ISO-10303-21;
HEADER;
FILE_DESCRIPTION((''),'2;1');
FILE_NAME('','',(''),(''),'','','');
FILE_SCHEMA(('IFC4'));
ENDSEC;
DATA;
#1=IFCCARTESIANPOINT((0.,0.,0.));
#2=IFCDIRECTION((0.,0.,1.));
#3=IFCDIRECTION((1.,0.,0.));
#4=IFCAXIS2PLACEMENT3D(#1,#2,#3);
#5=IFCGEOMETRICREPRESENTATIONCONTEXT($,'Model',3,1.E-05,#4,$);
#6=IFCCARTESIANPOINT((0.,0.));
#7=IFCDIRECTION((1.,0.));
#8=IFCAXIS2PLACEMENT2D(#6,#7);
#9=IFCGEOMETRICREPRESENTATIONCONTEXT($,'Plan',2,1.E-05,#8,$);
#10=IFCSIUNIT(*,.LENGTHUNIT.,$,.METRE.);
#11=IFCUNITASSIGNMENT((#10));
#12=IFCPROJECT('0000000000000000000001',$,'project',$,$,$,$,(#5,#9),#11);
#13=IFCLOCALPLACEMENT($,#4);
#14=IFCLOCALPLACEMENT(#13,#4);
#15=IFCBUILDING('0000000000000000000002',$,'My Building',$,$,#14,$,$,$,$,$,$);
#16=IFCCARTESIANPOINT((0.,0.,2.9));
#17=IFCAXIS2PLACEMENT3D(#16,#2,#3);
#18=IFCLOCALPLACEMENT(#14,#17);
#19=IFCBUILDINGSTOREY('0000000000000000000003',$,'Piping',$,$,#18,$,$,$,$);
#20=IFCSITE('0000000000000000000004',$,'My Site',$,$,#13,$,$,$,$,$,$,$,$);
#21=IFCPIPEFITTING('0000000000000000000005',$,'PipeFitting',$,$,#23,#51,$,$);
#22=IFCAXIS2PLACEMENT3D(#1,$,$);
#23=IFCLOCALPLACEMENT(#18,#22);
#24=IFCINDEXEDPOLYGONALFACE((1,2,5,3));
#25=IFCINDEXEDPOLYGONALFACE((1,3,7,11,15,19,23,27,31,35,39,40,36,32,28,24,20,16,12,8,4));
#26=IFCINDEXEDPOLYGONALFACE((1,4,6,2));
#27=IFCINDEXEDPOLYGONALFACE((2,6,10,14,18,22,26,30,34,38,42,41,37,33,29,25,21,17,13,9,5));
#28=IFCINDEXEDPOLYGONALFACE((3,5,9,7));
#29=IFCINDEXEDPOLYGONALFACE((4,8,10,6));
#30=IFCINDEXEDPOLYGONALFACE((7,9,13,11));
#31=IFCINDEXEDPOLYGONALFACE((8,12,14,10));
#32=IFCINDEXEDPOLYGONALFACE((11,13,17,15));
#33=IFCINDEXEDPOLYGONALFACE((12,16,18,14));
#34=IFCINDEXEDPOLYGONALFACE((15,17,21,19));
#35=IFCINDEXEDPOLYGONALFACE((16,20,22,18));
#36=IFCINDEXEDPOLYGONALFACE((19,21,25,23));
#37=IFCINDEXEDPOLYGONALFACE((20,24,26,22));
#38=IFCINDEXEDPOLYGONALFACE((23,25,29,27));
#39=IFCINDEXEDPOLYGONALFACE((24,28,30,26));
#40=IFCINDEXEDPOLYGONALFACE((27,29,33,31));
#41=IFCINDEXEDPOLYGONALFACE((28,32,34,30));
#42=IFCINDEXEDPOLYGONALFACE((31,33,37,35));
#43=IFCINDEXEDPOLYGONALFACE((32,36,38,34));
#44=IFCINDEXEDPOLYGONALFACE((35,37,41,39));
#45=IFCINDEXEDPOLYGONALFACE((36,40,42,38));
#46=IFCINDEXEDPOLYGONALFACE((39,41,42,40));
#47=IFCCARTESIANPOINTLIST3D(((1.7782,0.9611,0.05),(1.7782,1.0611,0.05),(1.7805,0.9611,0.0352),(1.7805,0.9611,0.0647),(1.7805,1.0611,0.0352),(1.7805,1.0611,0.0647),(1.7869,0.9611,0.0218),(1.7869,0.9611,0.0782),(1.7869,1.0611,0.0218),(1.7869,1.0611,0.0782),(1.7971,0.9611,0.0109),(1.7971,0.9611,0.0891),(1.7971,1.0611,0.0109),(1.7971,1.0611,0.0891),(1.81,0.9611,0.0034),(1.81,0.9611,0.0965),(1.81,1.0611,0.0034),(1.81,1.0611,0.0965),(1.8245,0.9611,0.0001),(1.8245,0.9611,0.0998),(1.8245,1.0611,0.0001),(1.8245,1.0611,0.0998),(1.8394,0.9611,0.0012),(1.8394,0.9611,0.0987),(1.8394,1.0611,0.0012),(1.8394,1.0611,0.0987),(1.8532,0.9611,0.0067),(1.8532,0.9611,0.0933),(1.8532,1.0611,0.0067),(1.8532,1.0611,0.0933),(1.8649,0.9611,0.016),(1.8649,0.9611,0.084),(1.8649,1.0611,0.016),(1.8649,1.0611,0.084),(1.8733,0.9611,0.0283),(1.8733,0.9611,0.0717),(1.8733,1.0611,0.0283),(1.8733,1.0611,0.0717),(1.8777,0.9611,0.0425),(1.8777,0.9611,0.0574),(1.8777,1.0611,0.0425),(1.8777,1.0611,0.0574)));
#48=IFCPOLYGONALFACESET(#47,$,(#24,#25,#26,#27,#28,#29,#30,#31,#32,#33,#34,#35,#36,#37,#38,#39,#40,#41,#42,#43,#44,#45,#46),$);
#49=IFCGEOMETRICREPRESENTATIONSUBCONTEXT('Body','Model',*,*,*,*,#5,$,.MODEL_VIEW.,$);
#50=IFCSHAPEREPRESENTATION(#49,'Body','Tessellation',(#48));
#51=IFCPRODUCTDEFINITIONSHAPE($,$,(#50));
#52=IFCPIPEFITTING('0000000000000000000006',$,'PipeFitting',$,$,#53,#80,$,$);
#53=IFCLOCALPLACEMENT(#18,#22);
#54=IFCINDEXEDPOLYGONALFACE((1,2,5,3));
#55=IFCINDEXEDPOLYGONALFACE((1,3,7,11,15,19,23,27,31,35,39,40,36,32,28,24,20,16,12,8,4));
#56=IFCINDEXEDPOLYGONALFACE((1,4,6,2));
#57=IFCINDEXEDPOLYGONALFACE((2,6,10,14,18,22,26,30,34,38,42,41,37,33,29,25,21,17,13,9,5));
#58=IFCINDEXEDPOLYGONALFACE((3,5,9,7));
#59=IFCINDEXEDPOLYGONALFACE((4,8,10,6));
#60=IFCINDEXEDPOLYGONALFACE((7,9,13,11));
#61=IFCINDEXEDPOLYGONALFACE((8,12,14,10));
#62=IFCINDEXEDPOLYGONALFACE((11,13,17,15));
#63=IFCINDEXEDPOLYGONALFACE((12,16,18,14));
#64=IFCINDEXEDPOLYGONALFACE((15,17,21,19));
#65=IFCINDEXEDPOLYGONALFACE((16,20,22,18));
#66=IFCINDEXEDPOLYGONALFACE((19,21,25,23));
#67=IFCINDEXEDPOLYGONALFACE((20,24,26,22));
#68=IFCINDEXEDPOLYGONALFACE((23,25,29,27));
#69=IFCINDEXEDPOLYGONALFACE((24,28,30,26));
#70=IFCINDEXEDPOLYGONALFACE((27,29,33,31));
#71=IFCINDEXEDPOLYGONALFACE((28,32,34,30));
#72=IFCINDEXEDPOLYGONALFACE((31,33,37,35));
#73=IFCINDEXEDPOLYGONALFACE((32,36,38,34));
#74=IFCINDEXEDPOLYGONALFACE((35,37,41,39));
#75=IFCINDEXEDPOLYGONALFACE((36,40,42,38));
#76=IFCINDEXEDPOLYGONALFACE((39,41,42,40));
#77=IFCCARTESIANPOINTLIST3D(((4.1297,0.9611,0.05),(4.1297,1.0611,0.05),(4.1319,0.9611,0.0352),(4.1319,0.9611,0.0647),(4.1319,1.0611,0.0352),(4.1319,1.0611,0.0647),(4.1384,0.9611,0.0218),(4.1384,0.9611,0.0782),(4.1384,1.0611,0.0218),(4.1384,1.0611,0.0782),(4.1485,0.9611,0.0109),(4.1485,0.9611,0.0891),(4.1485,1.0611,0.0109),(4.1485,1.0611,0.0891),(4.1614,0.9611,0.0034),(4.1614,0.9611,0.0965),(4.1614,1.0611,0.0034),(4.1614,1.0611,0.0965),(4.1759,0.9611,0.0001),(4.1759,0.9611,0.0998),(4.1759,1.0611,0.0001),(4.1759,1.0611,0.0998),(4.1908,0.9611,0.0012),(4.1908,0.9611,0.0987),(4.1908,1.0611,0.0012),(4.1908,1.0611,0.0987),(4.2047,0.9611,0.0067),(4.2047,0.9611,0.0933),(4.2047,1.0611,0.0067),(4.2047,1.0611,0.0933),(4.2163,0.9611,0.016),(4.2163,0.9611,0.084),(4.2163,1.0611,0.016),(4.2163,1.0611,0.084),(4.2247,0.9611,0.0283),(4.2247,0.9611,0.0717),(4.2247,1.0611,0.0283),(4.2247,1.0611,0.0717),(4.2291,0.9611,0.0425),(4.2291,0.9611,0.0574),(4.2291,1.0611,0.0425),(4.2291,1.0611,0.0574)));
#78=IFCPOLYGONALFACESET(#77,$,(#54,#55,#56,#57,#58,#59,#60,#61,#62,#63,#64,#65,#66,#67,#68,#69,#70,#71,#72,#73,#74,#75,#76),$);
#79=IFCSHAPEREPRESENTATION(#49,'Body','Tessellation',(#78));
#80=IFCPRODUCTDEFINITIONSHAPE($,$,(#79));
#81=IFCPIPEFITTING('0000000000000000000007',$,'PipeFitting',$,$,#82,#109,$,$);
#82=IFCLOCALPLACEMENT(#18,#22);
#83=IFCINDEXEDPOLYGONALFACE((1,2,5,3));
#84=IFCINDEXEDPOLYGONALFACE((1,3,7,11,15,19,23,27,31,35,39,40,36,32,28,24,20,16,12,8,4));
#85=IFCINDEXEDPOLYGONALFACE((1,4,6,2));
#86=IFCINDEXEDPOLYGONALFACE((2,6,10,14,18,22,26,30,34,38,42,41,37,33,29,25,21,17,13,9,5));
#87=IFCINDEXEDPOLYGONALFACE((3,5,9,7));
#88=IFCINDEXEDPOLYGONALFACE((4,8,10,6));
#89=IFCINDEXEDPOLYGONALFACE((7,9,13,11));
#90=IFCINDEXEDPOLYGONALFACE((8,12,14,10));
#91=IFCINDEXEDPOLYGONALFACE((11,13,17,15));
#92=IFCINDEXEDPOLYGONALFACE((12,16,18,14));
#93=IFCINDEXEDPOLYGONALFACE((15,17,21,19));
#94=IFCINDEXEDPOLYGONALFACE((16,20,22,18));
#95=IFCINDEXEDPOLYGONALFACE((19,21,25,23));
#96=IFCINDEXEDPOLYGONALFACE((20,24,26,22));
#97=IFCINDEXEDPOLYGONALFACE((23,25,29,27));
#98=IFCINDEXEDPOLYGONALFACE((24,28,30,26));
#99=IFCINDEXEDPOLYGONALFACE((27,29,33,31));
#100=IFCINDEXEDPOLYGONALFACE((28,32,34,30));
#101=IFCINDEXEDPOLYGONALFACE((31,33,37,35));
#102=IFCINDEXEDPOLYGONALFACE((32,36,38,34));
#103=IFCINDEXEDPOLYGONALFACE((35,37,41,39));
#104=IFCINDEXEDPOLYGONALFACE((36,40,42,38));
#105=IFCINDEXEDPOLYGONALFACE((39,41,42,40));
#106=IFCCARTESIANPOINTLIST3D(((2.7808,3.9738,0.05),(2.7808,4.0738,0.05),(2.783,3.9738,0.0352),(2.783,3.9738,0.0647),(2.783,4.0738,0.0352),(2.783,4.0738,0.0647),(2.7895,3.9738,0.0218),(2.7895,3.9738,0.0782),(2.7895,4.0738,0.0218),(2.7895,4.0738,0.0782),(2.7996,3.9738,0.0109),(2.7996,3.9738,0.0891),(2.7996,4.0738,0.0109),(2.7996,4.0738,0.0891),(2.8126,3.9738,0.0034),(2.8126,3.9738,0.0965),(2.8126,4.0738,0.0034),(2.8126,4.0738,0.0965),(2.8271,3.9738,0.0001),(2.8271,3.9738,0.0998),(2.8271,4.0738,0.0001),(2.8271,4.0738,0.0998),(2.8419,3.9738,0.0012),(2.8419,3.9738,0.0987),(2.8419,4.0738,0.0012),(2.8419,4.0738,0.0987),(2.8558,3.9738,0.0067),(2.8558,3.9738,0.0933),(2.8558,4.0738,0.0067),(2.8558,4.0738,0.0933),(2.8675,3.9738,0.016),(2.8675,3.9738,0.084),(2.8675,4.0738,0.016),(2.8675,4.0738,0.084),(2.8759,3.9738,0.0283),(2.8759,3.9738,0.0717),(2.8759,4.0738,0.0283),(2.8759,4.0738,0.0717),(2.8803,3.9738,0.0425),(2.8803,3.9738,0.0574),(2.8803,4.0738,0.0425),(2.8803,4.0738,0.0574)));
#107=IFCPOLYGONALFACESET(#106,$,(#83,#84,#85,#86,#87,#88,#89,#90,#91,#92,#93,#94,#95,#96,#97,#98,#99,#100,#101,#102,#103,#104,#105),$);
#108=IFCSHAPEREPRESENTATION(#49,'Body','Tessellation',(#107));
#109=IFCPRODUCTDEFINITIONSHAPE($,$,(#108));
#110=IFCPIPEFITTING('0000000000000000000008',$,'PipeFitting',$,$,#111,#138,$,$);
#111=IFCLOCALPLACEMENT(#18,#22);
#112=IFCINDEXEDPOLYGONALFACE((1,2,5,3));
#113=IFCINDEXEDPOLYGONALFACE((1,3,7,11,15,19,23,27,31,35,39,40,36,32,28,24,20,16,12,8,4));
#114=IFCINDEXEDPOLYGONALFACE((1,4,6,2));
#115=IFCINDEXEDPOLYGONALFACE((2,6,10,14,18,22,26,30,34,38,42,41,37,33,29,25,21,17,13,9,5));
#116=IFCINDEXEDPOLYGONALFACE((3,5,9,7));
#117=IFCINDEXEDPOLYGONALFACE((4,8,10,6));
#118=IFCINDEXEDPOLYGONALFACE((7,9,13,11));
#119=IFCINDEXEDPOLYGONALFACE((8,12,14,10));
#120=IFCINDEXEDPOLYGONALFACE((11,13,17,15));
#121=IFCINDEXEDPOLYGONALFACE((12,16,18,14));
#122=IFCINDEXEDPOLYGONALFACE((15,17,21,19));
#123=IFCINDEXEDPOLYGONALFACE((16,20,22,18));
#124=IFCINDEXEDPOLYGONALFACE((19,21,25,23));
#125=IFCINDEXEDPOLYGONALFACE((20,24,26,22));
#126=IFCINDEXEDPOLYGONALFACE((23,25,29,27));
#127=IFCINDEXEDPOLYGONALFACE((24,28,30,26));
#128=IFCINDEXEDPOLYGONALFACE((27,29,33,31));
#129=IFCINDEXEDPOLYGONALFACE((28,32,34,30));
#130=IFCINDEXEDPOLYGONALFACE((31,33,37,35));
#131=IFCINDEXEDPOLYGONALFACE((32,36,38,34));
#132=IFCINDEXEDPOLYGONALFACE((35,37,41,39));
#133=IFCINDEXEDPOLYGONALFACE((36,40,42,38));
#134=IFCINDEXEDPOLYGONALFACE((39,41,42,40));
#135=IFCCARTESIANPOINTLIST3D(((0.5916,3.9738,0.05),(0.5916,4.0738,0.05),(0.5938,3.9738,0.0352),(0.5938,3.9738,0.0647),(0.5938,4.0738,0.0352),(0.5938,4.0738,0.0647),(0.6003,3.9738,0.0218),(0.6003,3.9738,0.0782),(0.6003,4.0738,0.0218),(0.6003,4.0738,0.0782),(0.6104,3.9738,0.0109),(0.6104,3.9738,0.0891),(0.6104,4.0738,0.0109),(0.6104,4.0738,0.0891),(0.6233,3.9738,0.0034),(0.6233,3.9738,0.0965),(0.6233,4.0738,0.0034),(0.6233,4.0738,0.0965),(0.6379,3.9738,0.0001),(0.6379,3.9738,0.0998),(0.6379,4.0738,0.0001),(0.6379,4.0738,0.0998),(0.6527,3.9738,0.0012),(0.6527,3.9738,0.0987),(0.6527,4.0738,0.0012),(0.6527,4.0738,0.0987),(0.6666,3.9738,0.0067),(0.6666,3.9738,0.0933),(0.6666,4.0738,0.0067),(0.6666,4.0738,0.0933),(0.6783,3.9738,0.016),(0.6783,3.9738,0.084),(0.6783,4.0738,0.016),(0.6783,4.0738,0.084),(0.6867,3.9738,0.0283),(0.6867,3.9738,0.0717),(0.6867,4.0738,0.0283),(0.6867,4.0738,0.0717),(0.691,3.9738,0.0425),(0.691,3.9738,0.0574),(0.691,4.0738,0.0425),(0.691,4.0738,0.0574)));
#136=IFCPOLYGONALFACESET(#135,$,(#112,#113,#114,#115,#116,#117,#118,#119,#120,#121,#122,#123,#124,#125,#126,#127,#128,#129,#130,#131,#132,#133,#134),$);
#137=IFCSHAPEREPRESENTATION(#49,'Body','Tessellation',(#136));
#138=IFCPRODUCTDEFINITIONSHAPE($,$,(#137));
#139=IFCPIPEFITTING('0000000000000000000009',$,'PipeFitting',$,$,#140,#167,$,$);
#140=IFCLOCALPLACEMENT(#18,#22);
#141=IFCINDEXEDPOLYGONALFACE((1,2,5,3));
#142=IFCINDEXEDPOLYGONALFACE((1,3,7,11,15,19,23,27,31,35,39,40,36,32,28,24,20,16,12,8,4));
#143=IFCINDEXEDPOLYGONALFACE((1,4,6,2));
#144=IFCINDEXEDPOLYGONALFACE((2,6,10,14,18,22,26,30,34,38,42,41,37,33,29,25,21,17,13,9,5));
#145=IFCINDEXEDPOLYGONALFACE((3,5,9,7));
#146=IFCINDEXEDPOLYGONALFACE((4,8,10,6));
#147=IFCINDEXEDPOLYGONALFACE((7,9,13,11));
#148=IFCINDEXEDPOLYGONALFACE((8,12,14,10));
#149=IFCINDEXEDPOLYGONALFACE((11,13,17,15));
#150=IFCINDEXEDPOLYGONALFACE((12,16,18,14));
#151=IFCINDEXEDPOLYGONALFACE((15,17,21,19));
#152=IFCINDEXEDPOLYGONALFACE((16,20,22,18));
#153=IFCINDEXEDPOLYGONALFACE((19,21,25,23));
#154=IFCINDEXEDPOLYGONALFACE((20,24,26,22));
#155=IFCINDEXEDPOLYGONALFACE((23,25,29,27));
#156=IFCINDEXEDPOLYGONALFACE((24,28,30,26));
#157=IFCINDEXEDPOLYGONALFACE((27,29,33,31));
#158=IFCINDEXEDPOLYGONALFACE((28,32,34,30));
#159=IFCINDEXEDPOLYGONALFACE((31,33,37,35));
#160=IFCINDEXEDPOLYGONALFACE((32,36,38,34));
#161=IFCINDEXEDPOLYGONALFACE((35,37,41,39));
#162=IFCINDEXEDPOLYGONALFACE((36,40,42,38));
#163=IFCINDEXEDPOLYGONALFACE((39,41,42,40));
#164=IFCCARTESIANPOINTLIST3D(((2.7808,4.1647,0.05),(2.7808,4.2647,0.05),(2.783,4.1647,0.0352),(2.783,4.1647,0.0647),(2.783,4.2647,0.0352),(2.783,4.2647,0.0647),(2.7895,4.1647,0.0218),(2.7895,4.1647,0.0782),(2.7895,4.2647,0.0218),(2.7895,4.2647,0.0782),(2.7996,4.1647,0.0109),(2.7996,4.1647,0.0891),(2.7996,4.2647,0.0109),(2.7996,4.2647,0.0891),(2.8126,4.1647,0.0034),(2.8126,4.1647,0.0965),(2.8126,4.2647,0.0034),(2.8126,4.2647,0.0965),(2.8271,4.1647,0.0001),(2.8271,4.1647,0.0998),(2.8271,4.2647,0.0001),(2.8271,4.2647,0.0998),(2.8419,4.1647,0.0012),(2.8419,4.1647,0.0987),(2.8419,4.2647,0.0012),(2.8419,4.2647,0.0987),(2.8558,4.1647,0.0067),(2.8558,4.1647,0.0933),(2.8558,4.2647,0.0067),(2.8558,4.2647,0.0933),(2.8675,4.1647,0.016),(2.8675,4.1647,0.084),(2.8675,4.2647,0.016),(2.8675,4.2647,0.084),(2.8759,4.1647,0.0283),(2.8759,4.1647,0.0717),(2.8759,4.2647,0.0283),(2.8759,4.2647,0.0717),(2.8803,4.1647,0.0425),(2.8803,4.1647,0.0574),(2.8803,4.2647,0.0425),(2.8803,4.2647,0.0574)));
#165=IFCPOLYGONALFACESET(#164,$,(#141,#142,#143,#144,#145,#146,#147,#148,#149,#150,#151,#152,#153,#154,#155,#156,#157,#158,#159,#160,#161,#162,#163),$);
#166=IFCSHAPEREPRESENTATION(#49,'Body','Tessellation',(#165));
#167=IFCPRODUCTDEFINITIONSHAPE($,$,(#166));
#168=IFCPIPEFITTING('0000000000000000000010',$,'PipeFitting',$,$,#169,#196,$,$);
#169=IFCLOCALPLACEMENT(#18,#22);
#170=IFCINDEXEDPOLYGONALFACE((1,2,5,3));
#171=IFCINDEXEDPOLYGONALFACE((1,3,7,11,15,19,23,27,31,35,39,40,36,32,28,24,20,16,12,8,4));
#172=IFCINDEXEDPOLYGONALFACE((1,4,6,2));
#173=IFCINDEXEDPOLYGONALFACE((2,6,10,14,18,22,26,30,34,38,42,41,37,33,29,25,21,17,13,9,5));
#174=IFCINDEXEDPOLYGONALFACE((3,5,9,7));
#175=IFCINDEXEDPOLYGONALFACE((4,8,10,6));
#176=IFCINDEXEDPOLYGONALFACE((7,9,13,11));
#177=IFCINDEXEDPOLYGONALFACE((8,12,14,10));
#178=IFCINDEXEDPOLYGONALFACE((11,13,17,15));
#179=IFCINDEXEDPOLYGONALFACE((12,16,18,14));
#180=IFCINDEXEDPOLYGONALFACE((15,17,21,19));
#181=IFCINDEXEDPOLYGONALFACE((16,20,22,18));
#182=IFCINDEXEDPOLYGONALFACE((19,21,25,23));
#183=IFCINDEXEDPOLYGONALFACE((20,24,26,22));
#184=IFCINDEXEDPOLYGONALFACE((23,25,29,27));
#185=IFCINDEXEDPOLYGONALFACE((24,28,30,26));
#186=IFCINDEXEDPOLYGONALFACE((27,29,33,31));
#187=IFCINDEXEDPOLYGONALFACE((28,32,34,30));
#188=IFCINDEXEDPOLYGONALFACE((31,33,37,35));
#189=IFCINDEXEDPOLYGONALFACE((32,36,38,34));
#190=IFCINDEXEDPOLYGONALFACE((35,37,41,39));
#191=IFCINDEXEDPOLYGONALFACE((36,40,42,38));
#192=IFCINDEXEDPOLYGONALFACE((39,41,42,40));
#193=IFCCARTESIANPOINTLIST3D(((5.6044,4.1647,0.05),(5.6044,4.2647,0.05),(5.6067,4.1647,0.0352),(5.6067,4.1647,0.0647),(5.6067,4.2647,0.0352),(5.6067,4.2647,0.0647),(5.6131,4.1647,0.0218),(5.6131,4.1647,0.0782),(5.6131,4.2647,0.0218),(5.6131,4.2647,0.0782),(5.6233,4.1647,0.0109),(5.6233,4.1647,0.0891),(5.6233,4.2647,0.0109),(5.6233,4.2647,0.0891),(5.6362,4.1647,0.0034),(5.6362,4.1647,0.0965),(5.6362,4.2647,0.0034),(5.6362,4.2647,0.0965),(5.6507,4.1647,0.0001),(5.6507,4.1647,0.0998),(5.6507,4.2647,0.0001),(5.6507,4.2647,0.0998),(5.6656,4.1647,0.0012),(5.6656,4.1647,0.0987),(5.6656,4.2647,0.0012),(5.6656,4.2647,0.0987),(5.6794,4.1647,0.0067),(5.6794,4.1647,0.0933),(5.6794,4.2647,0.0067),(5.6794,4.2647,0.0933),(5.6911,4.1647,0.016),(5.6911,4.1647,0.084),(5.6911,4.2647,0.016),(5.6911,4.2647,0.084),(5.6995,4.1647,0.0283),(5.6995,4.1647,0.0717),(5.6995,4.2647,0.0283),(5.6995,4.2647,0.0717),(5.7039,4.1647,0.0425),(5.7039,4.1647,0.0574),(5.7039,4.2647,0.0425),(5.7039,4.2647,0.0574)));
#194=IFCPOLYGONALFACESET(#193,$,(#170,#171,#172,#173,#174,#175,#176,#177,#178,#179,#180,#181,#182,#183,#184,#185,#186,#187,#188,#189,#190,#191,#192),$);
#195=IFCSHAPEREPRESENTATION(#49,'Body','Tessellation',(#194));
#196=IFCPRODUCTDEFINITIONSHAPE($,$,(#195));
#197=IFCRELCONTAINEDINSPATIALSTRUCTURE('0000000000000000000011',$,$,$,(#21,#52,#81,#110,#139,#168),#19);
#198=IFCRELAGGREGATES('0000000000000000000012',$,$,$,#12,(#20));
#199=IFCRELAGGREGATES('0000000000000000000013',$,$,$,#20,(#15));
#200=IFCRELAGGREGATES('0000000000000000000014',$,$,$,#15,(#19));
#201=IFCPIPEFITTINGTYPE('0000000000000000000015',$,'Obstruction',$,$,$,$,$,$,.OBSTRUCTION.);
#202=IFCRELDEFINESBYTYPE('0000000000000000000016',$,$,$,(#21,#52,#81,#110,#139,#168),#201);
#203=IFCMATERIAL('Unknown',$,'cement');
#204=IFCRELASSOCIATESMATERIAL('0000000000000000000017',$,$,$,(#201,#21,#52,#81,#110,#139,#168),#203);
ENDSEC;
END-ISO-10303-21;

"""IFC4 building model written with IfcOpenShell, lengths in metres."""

from ifc_helpers import new_model, si_unit, frame, origin_with_axes, origin_2d_with_axis, place, context, subcontext, project, spatial, circle, extrude, material, material_profile, profile_set, profile_usage, type_object, element, save


model = new_model("IFC4")

# Units and contexts
model_context = context("Model", 3, precision=1e-05, world=origin_with_axes())
plan_context = context("Plan", 2, precision=1e-05, world=origin_2d_with_axis())
body_context = subcontext(model_context, "Body", "Model", "MODEL_VIEW")
ifc_project = project(units=[si_unit("LENGTHUNIT", "METRE")], contexts=[model_context, plan_context])

# Site, building, storey
site_placement = place(None, origin_with_axes())
site = spatial("IfcSite", under=ifc_project, at=site_placement, Name="My Site")
building_placement = place(site_placement, origin_with_axes())
building = spatial("IfcBuilding", under=site, at=building_placement, Name="My Building")
storey_placement = place(building_placement, frame((0.0, 0.0, 2.9), z_axis=(0.0, 0.0, 1.0), x_axis=(1.0, 0.0, 0.0)))
storey = spatial("IfcBuildingStorey", under=building, at=storey_placement, Name="Piping")

# Shared definitions
ifc_material = material(Name="Unknown", Category="cement")

# Pipe fittings
ifc_material_profile_1 = material_profile(ifc_material, circle(Radius=0.05))
ifc_profile_set_1 = profile_set([ifc_material_profile_1])
ifc_profile_usage_1 = profile_usage(ifc_profile_set_1, cardinal=5)
pipe_fitting_type_1 = type_object("IfcPipeFittingType", Name="Obstruction", PredefinedType="OBSTRUCTION", material=ifc_profile_set_1)
pipe_fitting_1_placement = place(storey_placement, frame((1.8282, 0.9611, 0.05), z_axis=(0.0, 1.0, 0.0), x_axis=(-1.0, 0.0, 0.0)))
element("IfcPipeFitting", 1, at=pipe_fitting_1_placement, inside=storey, type_object=pipe_fitting_type_1, material=ifc_profile_usage_1, Name="PipeFitting", context=body_context, shape_type="SweptSolid", body=[
    extrude(circle(Radius=0.05), origin_with_axes(), (0.0, 0.0, 1.0), 0.1),
])
ifc_profile_usage_2 = profile_usage(ifc_profile_set_1, cardinal=5)
pipe_fitting_2_placement = place(storey_placement, frame((4.1797, 0.9611, 0.05), z_axis=(0.0, 1.0, 0.0), x_axis=(-1.0, 0.0, 0.0)))
element("IfcPipeFitting", 2, at=pipe_fitting_2_placement, inside=storey, type_object=pipe_fitting_type_1, material=ifc_profile_usage_2, Name="PipeFitting", context=body_context, shape_type="SweptSolid", body=[
    extrude(circle(Radius=0.05), origin_with_axes(), (0.0, 0.0, 1.0), 0.1),
])
ifc_profile_usage_3 = profile_usage(ifc_profile_set_1, cardinal=5)
pipe_fitting_3_placement = place(storey_placement, frame((2.8308, 3.9738, 0.05), z_axis=(0.0, 1.0, 0.0), x_axis=(-1.0, 0.0, 0.0)))
element("IfcPipeFitting", 3, at=pipe_fitting_3_placement, inside=storey, type_object=pipe_fitting_type_1, material=ifc_profile_usage_3, Name="PipeFitting", context=body_context, shape_type="SweptSolid", body=[
    extrude(circle(Radius=0.05), origin_with_axes(), (0.0, 0.0, 1.0), 0.1),
])
ifc_profile_usage_4 = profile_usage(ifc_profile_set_1, cardinal=5)
pipe_fitting_4_placement = place(storey_placement, frame((0.6416, 3.9738, 0.05), z_axis=(0.0, 1.0, 0.0), x_axis=(-1.0, 0.0, 0.0)))
element("IfcPipeFitting", 4, at=pipe_fitting_4_placement, inside=storey, type_object=pipe_fitting_type_1, material=ifc_profile_usage_4, Name="PipeFitting", context=body_context, shape_type="SweptSolid", body=[
    extrude(circle(Radius=0.05), origin_with_axes(), (0.0, 0.0, 1.0), 0.1),
])
ifc_profile_usage_5 = profile_usage(ifc_profile_set_1, cardinal=5)
pipe_fitting_5_placement = place(storey_placement, frame((2.8308, 4.1647, 0.05), z_axis=(0.0, 1.0, 0.0), x_axis=(-1.0, 0.0, 0.0)))
element("IfcPipeFitting", 5, at=pipe_fitting_5_placement, inside=storey, type_object=pipe_fitting_type_1, material=ifc_profile_usage_5, Name="PipeFitting", context=body_context, shape_type="SweptSolid", body=[
    extrude(circle(Radius=0.05), origin_with_axes(), (0.0, 0.0, 1.0), 0.1),
])
ifc_profile_usage_6 = profile_usage(ifc_profile_set_1, cardinal=5)
pipe_fitting_6_placement = place(storey_placement, frame((5.6544, 4.1647, 0.05), z_axis=(0.0, 1.0, 0.0), x_axis=(-1.0, 0.0, 0.0)))
element("IfcPipeFitting", 6, at=pipe_fitting_6_placement, inside=storey, type_object=pipe_fitting_type_1, material=ifc_profile_usage_6, Name="PipeFitting", context=body_context, shape_type="SweptSolid", body=[
    extrude(circle(Radius=0.05), origin_with_axes(), (0.0, 0.0, 1.0), 0.1),
])

save(model, "model.ifc")
